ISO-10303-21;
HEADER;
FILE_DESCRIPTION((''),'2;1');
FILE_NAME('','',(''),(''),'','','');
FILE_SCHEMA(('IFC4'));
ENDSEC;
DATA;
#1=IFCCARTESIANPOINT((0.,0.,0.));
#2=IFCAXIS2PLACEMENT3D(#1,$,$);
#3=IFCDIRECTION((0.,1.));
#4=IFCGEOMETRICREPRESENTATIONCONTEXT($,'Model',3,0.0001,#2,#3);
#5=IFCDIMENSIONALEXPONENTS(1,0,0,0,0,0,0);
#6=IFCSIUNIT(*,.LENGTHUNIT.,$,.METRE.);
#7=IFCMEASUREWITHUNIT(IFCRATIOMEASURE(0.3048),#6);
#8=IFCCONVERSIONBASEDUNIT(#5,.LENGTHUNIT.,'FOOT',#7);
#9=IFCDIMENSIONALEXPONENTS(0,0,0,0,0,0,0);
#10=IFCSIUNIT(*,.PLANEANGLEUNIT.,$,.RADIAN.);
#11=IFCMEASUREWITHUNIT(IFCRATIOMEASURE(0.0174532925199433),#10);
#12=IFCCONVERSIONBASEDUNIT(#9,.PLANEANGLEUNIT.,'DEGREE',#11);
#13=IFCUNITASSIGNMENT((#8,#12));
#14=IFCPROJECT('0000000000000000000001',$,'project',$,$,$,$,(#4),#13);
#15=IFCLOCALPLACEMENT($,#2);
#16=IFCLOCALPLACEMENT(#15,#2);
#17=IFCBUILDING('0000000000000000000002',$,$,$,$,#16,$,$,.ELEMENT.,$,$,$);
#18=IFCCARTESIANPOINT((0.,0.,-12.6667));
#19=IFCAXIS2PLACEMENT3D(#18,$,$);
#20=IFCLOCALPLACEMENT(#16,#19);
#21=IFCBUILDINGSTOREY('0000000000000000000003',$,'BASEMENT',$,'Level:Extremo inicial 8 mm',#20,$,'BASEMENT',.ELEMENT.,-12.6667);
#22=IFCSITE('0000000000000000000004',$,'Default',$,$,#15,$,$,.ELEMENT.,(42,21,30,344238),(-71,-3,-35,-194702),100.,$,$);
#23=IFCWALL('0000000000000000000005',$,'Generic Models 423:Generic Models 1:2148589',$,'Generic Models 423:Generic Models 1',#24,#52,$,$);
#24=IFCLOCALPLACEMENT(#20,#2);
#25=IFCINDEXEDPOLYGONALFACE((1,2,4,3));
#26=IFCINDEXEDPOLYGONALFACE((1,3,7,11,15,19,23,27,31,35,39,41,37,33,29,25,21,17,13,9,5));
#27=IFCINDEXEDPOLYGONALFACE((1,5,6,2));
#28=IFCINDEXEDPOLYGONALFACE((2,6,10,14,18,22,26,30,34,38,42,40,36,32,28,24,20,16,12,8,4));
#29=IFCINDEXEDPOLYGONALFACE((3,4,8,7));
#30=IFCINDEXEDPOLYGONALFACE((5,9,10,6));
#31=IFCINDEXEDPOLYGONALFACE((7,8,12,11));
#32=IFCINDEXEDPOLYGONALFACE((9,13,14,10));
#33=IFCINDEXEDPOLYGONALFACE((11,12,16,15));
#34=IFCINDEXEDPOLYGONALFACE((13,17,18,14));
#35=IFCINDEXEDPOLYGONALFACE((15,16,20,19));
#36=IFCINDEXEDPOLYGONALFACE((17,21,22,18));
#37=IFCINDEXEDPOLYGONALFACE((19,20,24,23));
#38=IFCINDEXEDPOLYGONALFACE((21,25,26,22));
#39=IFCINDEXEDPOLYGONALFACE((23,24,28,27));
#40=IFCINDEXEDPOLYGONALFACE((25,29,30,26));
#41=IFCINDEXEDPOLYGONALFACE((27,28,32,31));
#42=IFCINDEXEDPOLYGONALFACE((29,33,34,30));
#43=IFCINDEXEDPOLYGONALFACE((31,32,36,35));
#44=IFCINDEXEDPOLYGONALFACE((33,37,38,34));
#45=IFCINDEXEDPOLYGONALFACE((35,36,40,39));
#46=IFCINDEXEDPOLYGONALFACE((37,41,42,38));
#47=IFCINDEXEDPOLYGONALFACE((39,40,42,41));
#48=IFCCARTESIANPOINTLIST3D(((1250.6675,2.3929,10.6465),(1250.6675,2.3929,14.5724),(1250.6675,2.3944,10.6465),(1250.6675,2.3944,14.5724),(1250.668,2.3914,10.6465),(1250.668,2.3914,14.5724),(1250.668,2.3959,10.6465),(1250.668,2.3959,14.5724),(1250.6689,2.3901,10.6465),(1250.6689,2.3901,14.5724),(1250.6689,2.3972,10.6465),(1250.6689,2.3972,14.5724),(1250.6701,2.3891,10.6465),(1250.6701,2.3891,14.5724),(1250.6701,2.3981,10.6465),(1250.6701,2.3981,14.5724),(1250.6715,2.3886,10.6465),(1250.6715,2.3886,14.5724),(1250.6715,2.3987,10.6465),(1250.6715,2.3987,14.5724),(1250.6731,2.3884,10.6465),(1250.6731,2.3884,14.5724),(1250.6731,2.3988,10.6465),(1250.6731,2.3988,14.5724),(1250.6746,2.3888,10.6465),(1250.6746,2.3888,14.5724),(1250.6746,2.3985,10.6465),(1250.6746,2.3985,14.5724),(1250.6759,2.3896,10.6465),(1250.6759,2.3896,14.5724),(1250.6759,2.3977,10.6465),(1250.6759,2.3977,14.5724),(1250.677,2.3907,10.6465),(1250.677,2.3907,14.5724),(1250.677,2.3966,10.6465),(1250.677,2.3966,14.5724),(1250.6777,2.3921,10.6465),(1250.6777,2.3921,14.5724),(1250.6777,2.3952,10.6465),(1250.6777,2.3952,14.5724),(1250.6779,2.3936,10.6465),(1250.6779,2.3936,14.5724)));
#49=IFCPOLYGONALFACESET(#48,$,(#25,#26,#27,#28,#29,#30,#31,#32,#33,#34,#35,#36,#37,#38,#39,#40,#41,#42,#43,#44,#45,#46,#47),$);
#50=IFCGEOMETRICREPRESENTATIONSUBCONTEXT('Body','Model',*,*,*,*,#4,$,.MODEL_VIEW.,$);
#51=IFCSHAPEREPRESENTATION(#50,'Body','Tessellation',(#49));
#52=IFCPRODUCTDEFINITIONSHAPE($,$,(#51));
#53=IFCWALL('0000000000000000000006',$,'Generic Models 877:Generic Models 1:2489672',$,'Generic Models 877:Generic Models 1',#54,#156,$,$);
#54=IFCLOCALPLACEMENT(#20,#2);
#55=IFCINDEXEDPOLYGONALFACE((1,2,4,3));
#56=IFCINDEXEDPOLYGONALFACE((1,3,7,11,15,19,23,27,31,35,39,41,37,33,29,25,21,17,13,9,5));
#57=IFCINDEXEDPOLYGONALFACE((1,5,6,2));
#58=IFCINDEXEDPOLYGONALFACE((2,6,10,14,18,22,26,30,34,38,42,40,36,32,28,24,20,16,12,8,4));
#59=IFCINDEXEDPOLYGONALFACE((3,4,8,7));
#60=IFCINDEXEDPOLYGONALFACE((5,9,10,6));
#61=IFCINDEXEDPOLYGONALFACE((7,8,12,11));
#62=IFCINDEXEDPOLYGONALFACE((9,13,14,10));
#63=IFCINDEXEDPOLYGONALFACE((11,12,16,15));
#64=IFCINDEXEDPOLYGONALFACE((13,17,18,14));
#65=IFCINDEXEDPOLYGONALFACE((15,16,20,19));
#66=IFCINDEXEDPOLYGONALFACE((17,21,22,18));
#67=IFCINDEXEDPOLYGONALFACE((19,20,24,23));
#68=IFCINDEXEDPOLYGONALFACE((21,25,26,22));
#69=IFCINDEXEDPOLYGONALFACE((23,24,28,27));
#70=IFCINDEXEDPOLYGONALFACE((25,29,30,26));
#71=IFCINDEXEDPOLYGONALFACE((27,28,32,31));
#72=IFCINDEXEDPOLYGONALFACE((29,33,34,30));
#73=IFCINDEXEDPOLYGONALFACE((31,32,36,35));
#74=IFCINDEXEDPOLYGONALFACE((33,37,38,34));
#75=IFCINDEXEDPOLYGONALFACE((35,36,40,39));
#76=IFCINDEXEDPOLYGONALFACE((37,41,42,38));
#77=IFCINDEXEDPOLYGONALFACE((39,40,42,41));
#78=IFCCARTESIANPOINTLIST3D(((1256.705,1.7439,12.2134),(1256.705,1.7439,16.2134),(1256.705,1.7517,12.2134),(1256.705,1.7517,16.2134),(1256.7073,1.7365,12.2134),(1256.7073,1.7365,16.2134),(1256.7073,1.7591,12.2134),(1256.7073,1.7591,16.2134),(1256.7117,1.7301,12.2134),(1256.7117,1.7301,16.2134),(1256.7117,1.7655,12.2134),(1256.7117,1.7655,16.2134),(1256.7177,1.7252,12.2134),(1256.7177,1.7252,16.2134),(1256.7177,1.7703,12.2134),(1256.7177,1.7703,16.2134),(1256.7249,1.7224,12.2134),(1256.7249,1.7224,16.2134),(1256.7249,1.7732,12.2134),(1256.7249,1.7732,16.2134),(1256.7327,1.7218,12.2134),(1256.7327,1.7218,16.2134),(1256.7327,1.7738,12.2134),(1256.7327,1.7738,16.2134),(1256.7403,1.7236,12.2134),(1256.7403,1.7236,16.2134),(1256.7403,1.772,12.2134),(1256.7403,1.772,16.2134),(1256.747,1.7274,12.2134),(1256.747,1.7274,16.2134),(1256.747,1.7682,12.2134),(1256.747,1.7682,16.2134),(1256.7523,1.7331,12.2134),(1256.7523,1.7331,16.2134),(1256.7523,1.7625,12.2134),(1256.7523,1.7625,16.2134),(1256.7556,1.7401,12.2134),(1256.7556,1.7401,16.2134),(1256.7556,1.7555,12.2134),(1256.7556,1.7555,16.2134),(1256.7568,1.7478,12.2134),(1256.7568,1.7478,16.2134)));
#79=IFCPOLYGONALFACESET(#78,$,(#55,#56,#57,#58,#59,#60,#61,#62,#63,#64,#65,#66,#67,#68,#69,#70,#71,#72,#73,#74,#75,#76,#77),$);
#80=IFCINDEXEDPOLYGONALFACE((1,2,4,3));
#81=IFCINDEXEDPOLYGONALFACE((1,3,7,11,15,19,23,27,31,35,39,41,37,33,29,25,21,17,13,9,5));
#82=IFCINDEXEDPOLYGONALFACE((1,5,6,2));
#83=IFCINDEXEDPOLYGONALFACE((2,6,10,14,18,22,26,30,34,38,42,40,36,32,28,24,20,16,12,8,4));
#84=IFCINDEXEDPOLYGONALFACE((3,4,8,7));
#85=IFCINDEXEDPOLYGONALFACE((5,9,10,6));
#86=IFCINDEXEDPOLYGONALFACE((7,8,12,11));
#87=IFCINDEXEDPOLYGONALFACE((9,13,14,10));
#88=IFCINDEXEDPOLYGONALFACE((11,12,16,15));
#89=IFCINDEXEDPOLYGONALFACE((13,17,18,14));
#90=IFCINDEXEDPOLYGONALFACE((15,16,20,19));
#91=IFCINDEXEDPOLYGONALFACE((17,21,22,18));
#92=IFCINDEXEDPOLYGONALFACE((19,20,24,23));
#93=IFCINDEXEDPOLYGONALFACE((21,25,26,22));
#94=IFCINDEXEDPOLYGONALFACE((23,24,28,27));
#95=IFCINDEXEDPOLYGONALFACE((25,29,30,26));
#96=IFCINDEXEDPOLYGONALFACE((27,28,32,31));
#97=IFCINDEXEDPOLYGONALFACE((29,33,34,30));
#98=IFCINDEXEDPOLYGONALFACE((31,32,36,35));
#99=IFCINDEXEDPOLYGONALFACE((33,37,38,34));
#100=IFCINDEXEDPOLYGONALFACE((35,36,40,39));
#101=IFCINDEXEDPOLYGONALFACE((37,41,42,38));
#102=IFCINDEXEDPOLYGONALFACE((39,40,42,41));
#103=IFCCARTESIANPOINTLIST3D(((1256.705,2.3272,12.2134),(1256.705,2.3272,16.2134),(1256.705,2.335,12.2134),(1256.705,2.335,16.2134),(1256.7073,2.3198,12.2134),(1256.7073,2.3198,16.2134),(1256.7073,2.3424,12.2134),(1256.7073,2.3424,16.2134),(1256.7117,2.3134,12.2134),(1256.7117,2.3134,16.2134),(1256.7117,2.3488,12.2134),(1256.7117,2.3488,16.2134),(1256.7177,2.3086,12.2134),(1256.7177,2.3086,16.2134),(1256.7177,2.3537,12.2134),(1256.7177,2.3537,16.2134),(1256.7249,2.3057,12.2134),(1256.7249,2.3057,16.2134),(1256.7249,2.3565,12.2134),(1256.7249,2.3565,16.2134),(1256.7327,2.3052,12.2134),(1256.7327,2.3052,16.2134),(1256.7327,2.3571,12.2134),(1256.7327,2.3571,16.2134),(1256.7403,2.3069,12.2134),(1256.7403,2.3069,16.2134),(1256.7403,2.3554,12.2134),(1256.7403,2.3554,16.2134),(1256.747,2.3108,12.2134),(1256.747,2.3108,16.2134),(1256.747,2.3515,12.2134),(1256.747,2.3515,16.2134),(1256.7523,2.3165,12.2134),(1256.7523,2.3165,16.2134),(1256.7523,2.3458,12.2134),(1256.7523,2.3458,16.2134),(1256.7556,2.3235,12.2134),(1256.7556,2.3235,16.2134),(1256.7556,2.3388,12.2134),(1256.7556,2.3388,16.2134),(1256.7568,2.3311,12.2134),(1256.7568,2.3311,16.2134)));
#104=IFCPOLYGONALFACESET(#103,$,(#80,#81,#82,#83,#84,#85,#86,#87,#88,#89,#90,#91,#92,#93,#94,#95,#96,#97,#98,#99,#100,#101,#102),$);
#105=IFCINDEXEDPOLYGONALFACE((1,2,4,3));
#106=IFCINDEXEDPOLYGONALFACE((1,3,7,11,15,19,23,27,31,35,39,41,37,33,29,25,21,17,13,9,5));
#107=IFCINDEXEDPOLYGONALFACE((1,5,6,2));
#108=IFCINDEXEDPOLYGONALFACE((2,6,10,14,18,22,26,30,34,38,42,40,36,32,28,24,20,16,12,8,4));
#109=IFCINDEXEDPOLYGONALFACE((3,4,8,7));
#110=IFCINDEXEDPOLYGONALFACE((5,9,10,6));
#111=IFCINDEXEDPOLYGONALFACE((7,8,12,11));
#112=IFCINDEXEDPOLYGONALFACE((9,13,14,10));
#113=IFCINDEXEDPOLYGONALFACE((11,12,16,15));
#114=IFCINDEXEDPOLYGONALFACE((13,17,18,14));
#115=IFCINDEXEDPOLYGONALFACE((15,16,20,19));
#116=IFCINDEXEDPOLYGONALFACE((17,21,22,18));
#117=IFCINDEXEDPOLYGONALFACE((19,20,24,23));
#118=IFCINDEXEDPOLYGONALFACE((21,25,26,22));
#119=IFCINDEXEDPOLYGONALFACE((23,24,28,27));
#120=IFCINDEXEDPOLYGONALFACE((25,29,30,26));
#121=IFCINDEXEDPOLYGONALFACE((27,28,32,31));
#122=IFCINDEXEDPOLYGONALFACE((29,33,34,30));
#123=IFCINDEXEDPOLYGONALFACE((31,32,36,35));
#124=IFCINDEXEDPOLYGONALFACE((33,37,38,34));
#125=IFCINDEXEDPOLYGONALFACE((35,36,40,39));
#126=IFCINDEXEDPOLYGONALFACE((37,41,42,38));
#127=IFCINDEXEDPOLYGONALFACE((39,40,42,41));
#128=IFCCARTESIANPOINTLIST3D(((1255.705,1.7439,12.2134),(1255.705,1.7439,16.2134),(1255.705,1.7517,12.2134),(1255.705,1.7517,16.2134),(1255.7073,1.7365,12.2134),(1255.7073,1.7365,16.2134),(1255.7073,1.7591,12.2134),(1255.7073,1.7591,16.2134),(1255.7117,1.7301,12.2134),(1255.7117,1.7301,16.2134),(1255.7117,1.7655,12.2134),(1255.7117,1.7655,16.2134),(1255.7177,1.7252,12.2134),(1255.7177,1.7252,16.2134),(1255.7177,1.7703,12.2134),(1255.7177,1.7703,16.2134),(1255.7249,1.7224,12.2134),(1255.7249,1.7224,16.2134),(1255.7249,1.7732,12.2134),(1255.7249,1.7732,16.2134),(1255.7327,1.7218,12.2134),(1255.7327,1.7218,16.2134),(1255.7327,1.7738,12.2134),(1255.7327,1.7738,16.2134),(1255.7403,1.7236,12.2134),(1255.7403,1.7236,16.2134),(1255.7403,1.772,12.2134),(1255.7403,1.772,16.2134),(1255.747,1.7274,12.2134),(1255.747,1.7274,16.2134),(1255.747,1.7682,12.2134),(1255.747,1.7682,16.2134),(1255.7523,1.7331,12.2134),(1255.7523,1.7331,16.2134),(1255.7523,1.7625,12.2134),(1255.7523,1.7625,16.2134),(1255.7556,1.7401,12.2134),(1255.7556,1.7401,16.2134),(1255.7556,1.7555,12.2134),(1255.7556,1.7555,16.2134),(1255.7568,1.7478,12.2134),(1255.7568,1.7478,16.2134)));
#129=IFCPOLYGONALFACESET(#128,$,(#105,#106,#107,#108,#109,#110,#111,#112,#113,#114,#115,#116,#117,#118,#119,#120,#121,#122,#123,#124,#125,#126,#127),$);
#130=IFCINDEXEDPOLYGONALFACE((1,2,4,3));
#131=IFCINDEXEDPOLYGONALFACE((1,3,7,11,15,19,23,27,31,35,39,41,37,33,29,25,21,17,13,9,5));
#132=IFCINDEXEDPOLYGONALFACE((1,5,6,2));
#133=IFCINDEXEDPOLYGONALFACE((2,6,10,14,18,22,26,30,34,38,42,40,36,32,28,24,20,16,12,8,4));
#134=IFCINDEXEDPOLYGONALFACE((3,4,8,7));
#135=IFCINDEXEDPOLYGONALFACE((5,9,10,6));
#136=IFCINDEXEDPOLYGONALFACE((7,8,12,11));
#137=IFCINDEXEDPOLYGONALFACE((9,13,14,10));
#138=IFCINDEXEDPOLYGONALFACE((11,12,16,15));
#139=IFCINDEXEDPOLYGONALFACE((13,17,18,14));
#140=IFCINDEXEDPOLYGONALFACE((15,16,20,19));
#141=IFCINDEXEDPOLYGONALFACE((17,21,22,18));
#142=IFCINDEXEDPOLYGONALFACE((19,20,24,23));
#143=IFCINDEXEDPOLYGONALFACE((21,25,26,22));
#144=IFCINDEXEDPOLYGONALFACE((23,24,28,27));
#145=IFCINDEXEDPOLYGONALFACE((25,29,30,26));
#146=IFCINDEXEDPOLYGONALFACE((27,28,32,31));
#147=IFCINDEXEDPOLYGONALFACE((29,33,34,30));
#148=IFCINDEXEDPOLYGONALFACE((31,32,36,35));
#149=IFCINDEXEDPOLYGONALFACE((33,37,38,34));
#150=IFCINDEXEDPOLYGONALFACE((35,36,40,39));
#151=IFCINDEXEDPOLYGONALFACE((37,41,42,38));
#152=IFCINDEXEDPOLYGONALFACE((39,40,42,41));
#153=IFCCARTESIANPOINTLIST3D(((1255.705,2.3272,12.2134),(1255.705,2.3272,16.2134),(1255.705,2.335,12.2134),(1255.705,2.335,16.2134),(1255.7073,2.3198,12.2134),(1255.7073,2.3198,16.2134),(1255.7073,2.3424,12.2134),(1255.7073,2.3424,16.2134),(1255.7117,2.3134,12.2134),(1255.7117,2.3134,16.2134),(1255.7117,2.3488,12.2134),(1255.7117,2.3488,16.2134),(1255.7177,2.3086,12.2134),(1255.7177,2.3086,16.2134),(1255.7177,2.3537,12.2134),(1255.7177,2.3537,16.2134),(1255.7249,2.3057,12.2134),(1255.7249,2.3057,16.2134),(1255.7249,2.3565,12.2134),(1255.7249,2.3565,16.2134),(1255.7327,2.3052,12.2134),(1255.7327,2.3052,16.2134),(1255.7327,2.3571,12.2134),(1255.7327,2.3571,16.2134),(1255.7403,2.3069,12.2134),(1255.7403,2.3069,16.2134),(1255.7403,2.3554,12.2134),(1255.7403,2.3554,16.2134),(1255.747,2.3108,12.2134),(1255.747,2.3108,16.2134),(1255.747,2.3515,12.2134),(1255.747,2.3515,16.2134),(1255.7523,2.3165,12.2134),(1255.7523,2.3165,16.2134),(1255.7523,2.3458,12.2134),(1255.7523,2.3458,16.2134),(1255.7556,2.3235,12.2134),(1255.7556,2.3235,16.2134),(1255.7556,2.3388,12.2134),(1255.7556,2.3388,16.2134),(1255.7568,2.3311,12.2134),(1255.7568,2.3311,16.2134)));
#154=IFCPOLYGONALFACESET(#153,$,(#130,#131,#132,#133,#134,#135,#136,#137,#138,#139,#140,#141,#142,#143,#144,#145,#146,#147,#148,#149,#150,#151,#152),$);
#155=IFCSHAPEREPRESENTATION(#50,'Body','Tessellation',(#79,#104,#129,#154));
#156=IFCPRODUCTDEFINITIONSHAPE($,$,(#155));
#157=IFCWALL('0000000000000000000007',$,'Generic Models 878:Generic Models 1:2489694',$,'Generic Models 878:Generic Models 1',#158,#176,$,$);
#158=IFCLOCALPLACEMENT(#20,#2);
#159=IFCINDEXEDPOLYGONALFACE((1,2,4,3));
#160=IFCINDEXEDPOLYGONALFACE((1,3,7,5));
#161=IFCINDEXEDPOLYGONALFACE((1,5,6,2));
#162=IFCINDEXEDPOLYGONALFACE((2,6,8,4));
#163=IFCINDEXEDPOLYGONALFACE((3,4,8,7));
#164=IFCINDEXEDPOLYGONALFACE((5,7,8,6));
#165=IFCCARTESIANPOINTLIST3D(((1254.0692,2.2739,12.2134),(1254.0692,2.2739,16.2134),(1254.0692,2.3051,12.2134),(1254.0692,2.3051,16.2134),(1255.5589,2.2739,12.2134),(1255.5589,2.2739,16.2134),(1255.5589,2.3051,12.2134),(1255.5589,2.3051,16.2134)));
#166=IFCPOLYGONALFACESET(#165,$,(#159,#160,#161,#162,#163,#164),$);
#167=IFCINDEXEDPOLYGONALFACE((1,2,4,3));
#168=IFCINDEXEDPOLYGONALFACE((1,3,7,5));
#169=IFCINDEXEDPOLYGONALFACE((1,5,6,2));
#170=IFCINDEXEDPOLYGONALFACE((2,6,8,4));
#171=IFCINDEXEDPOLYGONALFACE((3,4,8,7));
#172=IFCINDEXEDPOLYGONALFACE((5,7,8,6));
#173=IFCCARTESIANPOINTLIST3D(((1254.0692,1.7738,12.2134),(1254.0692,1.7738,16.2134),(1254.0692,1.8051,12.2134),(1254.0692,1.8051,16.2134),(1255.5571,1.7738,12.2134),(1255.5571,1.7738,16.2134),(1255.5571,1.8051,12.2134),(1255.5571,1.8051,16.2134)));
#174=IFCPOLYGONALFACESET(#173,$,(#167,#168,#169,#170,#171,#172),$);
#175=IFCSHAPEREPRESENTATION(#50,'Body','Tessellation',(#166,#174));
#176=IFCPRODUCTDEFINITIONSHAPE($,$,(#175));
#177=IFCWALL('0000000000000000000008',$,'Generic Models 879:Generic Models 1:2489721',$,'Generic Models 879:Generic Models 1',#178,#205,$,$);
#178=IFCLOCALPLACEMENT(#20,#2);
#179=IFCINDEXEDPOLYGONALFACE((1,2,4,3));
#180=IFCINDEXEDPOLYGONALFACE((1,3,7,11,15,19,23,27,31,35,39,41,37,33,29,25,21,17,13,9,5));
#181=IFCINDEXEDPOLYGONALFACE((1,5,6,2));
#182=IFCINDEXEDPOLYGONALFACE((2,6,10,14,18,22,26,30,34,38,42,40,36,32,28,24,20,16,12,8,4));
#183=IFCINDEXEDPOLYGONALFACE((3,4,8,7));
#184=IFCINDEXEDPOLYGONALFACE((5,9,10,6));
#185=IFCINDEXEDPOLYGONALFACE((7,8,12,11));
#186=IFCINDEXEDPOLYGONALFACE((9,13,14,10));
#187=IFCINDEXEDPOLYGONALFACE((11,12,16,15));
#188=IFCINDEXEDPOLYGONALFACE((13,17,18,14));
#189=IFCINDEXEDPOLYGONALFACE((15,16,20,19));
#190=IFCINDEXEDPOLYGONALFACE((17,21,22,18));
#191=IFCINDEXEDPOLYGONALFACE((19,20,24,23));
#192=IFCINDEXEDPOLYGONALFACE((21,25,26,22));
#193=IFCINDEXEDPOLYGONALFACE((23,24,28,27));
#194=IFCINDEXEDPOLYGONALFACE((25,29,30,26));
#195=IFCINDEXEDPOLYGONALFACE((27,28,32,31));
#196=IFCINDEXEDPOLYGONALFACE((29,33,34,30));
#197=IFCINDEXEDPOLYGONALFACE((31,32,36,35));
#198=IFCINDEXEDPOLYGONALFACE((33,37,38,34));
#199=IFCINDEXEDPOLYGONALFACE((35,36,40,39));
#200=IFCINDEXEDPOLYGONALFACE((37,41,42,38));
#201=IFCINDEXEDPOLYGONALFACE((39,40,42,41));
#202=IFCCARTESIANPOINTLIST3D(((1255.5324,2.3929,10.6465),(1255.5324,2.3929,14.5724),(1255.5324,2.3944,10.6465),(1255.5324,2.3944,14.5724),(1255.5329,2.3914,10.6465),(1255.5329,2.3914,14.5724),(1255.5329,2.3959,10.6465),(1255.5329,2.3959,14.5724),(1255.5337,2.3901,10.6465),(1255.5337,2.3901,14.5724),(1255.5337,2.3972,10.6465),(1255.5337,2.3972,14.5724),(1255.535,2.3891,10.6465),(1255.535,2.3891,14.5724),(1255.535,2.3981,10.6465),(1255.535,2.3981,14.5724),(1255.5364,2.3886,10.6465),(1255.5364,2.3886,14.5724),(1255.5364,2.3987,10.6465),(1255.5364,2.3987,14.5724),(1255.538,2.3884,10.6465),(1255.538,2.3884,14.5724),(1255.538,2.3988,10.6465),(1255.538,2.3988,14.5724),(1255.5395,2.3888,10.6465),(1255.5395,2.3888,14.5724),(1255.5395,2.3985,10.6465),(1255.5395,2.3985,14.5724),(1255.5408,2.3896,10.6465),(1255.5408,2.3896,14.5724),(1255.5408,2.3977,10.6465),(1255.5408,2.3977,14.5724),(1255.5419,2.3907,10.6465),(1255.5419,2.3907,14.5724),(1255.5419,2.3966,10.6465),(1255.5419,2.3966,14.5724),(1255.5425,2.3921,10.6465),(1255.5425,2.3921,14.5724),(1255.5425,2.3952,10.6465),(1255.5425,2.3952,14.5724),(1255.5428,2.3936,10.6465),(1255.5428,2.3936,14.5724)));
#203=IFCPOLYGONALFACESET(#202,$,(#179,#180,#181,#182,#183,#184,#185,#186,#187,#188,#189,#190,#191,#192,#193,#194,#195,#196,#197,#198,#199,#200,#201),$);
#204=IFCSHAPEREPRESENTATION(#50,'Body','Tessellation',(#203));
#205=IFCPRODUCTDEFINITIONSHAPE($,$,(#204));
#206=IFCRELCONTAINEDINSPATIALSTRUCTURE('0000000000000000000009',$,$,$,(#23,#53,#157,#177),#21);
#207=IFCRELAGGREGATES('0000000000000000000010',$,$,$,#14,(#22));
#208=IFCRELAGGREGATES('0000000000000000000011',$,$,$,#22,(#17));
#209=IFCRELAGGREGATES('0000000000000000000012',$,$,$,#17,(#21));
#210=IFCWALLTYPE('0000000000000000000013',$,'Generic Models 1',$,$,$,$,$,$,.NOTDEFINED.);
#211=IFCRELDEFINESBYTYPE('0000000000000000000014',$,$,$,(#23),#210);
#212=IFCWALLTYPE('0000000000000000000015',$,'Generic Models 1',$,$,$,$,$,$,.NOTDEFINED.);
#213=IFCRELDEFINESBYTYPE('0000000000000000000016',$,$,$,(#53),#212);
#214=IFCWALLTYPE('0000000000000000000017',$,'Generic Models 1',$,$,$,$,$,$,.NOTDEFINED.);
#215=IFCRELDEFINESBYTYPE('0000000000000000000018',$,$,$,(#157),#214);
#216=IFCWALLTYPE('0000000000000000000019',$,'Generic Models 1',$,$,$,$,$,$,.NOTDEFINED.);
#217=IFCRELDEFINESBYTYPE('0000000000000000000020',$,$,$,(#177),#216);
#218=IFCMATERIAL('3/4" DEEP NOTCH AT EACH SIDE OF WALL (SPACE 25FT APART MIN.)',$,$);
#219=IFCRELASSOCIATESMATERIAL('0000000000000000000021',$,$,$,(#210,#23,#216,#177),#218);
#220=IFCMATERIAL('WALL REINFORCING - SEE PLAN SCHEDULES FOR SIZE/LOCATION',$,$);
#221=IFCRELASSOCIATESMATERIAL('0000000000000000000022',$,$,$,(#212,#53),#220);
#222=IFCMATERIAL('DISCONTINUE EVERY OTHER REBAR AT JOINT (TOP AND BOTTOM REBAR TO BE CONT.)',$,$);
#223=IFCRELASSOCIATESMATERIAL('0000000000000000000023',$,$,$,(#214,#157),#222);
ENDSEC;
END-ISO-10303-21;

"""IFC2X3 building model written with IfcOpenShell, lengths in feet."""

from ifc_helpers import new_model, entity, si_unit, converted_unit, direction, frame, frame_2d, origin, origin_2d_with_axis, place, context, subcontext, project, spatial, rectangle, circle, extrude, material, type_object, element, save


model = new_model("IFC2X3")

# Units and contexts
model_context = context("Model", 3, precision=0.0001, world=origin(), true_north=direction((0.0, 1.0)))
body_context = subcontext(model_context, "Body", "Model", "MODEL_VIEW")
ifc_project = project(units=[converted_unit("LENGTHUNIT", "FOOT", entity("IfcRatioMeasure", 0.3048), si_unit("LENGTHUNIT", "METRE"), dimensions=[1, 0, 0, 0, 0, 0, 0]), converted_unit("PLANEANGLEUNIT", "DEGREE", entity("IfcRatioMeasure", 0.0174532925199433), si_unit("PLANEANGLEUNIT", "RADIAN"), dimensions=[0, 0, 0, 0, 0, 0, 0])], contexts=[model_context])

# Site, building, storey
site_placement = place(None, origin())
site = spatial("IfcSite", under=ifc_project, at=site_placement, Name="Default", CompositionType="ELEMENT", RefLatitude=(42, 21, 30, 344238), RefLongitude=(-71, -3, -35, -194702), RefElevation=100.0)
building_placement = place(site_placement, origin())
building = spatial("IfcBuilding", under=site, at=building_placement, CompositionType="ELEMENT")
storey_placement = place(building_placement, frame((0.0, 0.0, -12.6667)))
storey = spatial("IfcBuildingStorey", under=building, at=storey_placement, Name="BASEMENT", ObjectType="Level:Extremo inicial 8 mm", LongName="BASEMENT", CompositionType="ELEMENT", Elevation=-12.6667)

# Walls
ifc_material_1 = material(Name="WALL REINFORCING - SEE PLAN SCHEDULES FOR SIZE/LOCATION")
ifc_material_2 = material(Name="DISCONTINUE EVERY OTHER REBAR AT JOINT (TOP AND BOTTOM REBAR TO BE CONT.)")
ifc_material_3 = material(Name="3/4\" DEEP NOTCH AT EACH SIDE OF WALL (SPACE 25FT APART MIN.)")
wall_type_1 = type_object("IfcWallType", Name="Generic Models 1", PredefinedType="NOTDEFINED", material=ifc_material_3)
wall_1_placement = place(storey_placement, frame((1250.6675, 2.3884, 10.6465), z_axis=(0.0, 0.0, 1.0), x_axis=(0.0, 1.0, 0.0)))
element("IfcWall", 1, at=wall_1_placement, inside=storey, type_object=wall_type_1, material=ifc_material_3, Name="Generic Models 423:Generic Models 1:2148589", ObjectType="Generic Models 423:Generic Models 1", context=body_context, shape_type="SweptSolid", body=[
    extrude(circle(Radius=0.0052, at=origin_2d_with_axis()), frame((0.0052, -0.0052, 0.0), z_axis=(0.0, 0.0, 1.0), x_axis=(0.0, -1.0, 0.0)), (0.0, 0.0, 1.0), 3.9258),
])
wall_type_2 = type_object("IfcWallType", Name="Generic Models 1", PredefinedType="NOTDEFINED", material=ifc_material_1)
wall_2_placement = place(storey_placement, frame((1255.7047, 1.7218, 12.2134)))
element("IfcWall", 2, at=wall_2_placement, inside=storey, type_object=wall_type_2, material=ifc_material_1, Name="Generic Models 877:Generic Models 1:2489672", ObjectType="Generic Models 877:Generic Models 1", context=body_context, shape_type="SweptSolid", body=[
    extrude(circle(Radius=0.026, at=origin_2d_with_axis()), frame((1.026, 0.026, 0.0)), (0.0, 0.0, 1.0), 4.0),
    extrude(circle(Radius=0.026, at=origin_2d_with_axis()), frame((1.026, 0.6094, 0.0)), (0.0, 0.0, 1.0), 4.0),
    extrude(circle(Radius=0.026, at=origin_2d_with_axis()), frame((0.026, 0.026, 0.0)), (0.0, 0.0, 1.0), 4.0),
    extrude(circle(Radius=0.026, at=origin_2d_with_axis()), frame((0.026, 0.6094, 0.0)), (0.0, 0.0, 1.0), 4.0),
])
wall_type_3 = type_object("IfcWallType", Name="Generic Models 1", PredefinedType="NOTDEFINED", material=ifc_material_2)
wall_3_placement = place(storey_placement, frame((1254.0692, 1.7738, 12.2134)))
element("IfcWall", 3, at=wall_3_placement, inside=storey, type_object=wall_type_3, material=ifc_material_2, Name="Generic Models 878:Generic Models 1:2489694", ObjectType="Generic Models 878:Generic Models 1", context=body_context, shape_type="SweptSolid", body=[
    extrude(rectangle(XDim=0.0312, YDim=1.4897, at=frame_2d((0.0, 0.0), x_axis=(1.0, 0.0))), frame((0.7448, 0.5157, 0.0), z_axis=(0.0, 0.0, 1.0), x_axis=(0.0, 1.0, 0.0)), (0.0, 0.0, 1.0), 4.0),
    extrude(rectangle(XDim=0.0312, YDim=1.4879, at=frame_2d((0.0, 0.0), x_axis=(1.0, 0.0))), frame((0.744, 0.0156, 0.0), z_axis=(0.0, 0.0, 1.0), x_axis=(0.0, 1.0, 0.0)), (0.0, 0.0, 1.0), 4.0),
])
wall_type_4 = type_object("IfcWallType", Name="Generic Models 1", PredefinedType="NOTDEFINED", material=ifc_material_3)
wall_4_placement = place(storey_placement, frame((1255.5324, 2.3884, 10.6465), z_axis=(0.0, 0.0, 1.0), x_axis=(0.0, 1.0, 0.0)))
element("IfcWall", 4, at=wall_4_placement, inside=storey, type_object=wall_type_4, material=ifc_material_3, Name="Generic Models 879:Generic Models 1:2489721", ObjectType="Generic Models 879:Generic Models 1", context=body_context, shape_type="SweptSolid", body=[
    extrude(circle(Radius=0.0052, at=origin_2d_with_axis()), frame((0.0052, -0.0052, 0.0), z_axis=(0.0, 0.0, 1.0), x_axis=(0.0, -1.0, 0.0)), (0.0, 0.0, 1.0), 3.9258),
])

save(model, "model.ifc")
